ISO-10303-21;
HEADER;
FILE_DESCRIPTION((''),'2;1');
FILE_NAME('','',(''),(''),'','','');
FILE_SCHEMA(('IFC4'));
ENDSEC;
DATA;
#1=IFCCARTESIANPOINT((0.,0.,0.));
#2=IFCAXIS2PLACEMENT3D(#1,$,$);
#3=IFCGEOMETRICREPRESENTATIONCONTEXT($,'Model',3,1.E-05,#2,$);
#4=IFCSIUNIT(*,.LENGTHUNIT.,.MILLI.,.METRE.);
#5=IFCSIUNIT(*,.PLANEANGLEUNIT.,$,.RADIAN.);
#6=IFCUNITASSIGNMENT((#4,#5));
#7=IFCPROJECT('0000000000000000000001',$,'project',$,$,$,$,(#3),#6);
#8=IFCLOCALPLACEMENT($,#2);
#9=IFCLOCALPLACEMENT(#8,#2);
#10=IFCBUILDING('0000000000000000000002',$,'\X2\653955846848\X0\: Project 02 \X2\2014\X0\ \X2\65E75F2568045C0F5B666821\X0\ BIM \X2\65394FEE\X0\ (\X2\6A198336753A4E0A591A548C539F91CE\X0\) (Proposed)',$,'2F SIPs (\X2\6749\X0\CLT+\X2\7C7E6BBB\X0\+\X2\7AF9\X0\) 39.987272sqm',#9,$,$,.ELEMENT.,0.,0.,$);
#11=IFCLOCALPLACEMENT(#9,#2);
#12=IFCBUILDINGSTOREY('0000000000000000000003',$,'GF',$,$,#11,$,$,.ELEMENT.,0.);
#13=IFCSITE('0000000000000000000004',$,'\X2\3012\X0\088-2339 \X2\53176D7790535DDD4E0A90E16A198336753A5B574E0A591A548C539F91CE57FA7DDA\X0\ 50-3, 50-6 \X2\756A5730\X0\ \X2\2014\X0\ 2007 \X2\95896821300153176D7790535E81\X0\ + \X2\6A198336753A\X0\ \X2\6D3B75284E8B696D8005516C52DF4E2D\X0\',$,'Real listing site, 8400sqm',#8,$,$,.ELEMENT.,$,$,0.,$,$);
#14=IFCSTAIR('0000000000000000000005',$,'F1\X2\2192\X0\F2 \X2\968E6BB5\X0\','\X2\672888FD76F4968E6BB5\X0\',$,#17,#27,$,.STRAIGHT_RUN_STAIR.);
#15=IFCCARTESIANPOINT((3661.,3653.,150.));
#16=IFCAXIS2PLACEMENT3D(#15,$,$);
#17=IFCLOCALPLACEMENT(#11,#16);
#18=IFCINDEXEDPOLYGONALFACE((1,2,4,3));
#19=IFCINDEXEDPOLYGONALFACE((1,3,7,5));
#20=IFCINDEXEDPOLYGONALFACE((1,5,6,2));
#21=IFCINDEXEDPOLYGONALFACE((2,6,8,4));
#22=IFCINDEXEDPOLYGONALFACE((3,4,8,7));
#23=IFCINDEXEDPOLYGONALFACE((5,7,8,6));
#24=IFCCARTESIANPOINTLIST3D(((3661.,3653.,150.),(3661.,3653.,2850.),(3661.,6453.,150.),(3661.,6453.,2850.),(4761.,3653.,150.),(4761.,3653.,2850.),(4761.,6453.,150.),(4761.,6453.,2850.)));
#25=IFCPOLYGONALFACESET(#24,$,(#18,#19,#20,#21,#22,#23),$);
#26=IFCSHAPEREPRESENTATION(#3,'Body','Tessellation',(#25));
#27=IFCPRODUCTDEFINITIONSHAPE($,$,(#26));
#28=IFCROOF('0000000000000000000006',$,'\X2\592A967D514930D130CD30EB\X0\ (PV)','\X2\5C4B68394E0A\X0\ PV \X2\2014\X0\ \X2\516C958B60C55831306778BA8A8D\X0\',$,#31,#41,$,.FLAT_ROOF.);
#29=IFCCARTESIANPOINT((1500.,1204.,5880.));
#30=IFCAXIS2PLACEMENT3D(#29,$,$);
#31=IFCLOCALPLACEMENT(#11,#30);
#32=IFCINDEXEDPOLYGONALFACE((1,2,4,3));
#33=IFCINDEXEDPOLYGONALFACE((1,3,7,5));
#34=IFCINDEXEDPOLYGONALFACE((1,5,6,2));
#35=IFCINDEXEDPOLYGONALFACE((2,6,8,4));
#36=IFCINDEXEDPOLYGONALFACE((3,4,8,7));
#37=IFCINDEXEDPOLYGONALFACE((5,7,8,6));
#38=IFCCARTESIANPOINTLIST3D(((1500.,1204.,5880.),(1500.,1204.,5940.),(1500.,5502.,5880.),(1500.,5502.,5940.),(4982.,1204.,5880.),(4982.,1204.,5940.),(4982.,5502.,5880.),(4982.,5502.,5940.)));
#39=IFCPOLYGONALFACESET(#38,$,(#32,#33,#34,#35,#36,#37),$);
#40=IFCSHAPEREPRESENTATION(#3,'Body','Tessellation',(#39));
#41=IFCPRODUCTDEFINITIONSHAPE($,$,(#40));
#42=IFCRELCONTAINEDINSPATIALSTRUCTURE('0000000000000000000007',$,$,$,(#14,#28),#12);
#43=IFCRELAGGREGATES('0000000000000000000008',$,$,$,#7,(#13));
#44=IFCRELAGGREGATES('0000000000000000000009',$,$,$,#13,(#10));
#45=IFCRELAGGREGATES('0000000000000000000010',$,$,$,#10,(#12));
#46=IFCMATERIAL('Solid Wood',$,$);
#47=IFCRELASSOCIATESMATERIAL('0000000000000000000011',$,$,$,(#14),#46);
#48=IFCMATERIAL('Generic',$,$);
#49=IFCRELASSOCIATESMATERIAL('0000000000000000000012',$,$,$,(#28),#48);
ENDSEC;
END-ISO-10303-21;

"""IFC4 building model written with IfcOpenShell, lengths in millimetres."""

from ifc_helpers import new_model, si_unit, frame, frame_2d, origin, place, context, project, spatial, rectangle, extrude, material, element, save


model = new_model("IFC4")

# Units and contexts
model_context = context("Model", 3, precision=1e-05, world=origin())
ifc_project = project(units=[si_unit("LENGTHUNIT", "METRE", prefix="MILLI"), si_unit("PLANEANGLEUNIT", "RADIAN")], contexts=[model_context])

# Site, building, storey
site_placement = place(None, origin())
site = spatial("IfcSite", under=ifc_project, at=site_placement, Name="〒088-2339 北海道川上郡標茶町字上多和原野基線 50-3, 50-6 番地 — 2007 閉校、北海道庁 + 標茶町 活用事業者公募中", ObjectType="Real listing site, 8400sqm", CompositionType="ELEMENT", RefElevation=0.0)
building_placement = place(site_placement, origin())
building = spatial("IfcBuilding", under=site, at=building_placement, Name="改善案: Project 02 — 旧弥栄小学校 BIM 改修 (標茶町上多和原野) (Proposed)", ObjectType="2F SIPs (杉CLT+籾殻+竹) 39.987272sqm", CompositionType="ELEMENT", ElevationOfRefHeight=0.0, ElevationOfTerrain=0.0)
storey_placement = place(building_placement, origin())
storey = spatial("IfcBuildingStorey", under=building, at=storey_placement, Name="GF", CompositionType="ELEMENT", Elevation=0.0)

# Shared definitions
ifc_material_1 = material(Name="Generic")

# Stair
ifc_material_2 = material(Name="Solid Wood")
stair_placement = place(storey_placement, frame((3661.0, 3653.0, 150.0)))
element("IfcStair", 1, at=stair_placement, inside=storey, material=ifc_material_2, Name="F1→F2 階段", Description="木製直階段", PredefinedType="STRAIGHT_RUN_STAIR", context=model_context, shape_type="SweptSolid", body=[
    extrude(rectangle(XDim=1100.0, YDim=2800.0, at=frame_2d((550.0, 1400.0))), frame((3661.0, 3653.0, 150.0)), (0.0, 0.0, 1.0), 2700.0),
])

# Roof
roof_placement = place(storey_placement, frame((1500.0, 1204.0, 5880.0)))
element("IfcRoof", 2, at=roof_placement, inside=storey, material=ifc_material_1, Name="太陽光パネル (PV)", Description="屋根上 PV — 公開情報で確認", PredefinedType="FLAT_ROOF", context=model_context, shape_type="SweptSolid", body=[
    extrude(rectangle(XDim=3482.0, YDim=4298.0, at=frame_2d((1741.0, 2149.0))), frame((1500.0, 1204.0, 5880.0)), (0.0, 0.0, 1.0), 60.0),
])

save(model, "model.ifc")
